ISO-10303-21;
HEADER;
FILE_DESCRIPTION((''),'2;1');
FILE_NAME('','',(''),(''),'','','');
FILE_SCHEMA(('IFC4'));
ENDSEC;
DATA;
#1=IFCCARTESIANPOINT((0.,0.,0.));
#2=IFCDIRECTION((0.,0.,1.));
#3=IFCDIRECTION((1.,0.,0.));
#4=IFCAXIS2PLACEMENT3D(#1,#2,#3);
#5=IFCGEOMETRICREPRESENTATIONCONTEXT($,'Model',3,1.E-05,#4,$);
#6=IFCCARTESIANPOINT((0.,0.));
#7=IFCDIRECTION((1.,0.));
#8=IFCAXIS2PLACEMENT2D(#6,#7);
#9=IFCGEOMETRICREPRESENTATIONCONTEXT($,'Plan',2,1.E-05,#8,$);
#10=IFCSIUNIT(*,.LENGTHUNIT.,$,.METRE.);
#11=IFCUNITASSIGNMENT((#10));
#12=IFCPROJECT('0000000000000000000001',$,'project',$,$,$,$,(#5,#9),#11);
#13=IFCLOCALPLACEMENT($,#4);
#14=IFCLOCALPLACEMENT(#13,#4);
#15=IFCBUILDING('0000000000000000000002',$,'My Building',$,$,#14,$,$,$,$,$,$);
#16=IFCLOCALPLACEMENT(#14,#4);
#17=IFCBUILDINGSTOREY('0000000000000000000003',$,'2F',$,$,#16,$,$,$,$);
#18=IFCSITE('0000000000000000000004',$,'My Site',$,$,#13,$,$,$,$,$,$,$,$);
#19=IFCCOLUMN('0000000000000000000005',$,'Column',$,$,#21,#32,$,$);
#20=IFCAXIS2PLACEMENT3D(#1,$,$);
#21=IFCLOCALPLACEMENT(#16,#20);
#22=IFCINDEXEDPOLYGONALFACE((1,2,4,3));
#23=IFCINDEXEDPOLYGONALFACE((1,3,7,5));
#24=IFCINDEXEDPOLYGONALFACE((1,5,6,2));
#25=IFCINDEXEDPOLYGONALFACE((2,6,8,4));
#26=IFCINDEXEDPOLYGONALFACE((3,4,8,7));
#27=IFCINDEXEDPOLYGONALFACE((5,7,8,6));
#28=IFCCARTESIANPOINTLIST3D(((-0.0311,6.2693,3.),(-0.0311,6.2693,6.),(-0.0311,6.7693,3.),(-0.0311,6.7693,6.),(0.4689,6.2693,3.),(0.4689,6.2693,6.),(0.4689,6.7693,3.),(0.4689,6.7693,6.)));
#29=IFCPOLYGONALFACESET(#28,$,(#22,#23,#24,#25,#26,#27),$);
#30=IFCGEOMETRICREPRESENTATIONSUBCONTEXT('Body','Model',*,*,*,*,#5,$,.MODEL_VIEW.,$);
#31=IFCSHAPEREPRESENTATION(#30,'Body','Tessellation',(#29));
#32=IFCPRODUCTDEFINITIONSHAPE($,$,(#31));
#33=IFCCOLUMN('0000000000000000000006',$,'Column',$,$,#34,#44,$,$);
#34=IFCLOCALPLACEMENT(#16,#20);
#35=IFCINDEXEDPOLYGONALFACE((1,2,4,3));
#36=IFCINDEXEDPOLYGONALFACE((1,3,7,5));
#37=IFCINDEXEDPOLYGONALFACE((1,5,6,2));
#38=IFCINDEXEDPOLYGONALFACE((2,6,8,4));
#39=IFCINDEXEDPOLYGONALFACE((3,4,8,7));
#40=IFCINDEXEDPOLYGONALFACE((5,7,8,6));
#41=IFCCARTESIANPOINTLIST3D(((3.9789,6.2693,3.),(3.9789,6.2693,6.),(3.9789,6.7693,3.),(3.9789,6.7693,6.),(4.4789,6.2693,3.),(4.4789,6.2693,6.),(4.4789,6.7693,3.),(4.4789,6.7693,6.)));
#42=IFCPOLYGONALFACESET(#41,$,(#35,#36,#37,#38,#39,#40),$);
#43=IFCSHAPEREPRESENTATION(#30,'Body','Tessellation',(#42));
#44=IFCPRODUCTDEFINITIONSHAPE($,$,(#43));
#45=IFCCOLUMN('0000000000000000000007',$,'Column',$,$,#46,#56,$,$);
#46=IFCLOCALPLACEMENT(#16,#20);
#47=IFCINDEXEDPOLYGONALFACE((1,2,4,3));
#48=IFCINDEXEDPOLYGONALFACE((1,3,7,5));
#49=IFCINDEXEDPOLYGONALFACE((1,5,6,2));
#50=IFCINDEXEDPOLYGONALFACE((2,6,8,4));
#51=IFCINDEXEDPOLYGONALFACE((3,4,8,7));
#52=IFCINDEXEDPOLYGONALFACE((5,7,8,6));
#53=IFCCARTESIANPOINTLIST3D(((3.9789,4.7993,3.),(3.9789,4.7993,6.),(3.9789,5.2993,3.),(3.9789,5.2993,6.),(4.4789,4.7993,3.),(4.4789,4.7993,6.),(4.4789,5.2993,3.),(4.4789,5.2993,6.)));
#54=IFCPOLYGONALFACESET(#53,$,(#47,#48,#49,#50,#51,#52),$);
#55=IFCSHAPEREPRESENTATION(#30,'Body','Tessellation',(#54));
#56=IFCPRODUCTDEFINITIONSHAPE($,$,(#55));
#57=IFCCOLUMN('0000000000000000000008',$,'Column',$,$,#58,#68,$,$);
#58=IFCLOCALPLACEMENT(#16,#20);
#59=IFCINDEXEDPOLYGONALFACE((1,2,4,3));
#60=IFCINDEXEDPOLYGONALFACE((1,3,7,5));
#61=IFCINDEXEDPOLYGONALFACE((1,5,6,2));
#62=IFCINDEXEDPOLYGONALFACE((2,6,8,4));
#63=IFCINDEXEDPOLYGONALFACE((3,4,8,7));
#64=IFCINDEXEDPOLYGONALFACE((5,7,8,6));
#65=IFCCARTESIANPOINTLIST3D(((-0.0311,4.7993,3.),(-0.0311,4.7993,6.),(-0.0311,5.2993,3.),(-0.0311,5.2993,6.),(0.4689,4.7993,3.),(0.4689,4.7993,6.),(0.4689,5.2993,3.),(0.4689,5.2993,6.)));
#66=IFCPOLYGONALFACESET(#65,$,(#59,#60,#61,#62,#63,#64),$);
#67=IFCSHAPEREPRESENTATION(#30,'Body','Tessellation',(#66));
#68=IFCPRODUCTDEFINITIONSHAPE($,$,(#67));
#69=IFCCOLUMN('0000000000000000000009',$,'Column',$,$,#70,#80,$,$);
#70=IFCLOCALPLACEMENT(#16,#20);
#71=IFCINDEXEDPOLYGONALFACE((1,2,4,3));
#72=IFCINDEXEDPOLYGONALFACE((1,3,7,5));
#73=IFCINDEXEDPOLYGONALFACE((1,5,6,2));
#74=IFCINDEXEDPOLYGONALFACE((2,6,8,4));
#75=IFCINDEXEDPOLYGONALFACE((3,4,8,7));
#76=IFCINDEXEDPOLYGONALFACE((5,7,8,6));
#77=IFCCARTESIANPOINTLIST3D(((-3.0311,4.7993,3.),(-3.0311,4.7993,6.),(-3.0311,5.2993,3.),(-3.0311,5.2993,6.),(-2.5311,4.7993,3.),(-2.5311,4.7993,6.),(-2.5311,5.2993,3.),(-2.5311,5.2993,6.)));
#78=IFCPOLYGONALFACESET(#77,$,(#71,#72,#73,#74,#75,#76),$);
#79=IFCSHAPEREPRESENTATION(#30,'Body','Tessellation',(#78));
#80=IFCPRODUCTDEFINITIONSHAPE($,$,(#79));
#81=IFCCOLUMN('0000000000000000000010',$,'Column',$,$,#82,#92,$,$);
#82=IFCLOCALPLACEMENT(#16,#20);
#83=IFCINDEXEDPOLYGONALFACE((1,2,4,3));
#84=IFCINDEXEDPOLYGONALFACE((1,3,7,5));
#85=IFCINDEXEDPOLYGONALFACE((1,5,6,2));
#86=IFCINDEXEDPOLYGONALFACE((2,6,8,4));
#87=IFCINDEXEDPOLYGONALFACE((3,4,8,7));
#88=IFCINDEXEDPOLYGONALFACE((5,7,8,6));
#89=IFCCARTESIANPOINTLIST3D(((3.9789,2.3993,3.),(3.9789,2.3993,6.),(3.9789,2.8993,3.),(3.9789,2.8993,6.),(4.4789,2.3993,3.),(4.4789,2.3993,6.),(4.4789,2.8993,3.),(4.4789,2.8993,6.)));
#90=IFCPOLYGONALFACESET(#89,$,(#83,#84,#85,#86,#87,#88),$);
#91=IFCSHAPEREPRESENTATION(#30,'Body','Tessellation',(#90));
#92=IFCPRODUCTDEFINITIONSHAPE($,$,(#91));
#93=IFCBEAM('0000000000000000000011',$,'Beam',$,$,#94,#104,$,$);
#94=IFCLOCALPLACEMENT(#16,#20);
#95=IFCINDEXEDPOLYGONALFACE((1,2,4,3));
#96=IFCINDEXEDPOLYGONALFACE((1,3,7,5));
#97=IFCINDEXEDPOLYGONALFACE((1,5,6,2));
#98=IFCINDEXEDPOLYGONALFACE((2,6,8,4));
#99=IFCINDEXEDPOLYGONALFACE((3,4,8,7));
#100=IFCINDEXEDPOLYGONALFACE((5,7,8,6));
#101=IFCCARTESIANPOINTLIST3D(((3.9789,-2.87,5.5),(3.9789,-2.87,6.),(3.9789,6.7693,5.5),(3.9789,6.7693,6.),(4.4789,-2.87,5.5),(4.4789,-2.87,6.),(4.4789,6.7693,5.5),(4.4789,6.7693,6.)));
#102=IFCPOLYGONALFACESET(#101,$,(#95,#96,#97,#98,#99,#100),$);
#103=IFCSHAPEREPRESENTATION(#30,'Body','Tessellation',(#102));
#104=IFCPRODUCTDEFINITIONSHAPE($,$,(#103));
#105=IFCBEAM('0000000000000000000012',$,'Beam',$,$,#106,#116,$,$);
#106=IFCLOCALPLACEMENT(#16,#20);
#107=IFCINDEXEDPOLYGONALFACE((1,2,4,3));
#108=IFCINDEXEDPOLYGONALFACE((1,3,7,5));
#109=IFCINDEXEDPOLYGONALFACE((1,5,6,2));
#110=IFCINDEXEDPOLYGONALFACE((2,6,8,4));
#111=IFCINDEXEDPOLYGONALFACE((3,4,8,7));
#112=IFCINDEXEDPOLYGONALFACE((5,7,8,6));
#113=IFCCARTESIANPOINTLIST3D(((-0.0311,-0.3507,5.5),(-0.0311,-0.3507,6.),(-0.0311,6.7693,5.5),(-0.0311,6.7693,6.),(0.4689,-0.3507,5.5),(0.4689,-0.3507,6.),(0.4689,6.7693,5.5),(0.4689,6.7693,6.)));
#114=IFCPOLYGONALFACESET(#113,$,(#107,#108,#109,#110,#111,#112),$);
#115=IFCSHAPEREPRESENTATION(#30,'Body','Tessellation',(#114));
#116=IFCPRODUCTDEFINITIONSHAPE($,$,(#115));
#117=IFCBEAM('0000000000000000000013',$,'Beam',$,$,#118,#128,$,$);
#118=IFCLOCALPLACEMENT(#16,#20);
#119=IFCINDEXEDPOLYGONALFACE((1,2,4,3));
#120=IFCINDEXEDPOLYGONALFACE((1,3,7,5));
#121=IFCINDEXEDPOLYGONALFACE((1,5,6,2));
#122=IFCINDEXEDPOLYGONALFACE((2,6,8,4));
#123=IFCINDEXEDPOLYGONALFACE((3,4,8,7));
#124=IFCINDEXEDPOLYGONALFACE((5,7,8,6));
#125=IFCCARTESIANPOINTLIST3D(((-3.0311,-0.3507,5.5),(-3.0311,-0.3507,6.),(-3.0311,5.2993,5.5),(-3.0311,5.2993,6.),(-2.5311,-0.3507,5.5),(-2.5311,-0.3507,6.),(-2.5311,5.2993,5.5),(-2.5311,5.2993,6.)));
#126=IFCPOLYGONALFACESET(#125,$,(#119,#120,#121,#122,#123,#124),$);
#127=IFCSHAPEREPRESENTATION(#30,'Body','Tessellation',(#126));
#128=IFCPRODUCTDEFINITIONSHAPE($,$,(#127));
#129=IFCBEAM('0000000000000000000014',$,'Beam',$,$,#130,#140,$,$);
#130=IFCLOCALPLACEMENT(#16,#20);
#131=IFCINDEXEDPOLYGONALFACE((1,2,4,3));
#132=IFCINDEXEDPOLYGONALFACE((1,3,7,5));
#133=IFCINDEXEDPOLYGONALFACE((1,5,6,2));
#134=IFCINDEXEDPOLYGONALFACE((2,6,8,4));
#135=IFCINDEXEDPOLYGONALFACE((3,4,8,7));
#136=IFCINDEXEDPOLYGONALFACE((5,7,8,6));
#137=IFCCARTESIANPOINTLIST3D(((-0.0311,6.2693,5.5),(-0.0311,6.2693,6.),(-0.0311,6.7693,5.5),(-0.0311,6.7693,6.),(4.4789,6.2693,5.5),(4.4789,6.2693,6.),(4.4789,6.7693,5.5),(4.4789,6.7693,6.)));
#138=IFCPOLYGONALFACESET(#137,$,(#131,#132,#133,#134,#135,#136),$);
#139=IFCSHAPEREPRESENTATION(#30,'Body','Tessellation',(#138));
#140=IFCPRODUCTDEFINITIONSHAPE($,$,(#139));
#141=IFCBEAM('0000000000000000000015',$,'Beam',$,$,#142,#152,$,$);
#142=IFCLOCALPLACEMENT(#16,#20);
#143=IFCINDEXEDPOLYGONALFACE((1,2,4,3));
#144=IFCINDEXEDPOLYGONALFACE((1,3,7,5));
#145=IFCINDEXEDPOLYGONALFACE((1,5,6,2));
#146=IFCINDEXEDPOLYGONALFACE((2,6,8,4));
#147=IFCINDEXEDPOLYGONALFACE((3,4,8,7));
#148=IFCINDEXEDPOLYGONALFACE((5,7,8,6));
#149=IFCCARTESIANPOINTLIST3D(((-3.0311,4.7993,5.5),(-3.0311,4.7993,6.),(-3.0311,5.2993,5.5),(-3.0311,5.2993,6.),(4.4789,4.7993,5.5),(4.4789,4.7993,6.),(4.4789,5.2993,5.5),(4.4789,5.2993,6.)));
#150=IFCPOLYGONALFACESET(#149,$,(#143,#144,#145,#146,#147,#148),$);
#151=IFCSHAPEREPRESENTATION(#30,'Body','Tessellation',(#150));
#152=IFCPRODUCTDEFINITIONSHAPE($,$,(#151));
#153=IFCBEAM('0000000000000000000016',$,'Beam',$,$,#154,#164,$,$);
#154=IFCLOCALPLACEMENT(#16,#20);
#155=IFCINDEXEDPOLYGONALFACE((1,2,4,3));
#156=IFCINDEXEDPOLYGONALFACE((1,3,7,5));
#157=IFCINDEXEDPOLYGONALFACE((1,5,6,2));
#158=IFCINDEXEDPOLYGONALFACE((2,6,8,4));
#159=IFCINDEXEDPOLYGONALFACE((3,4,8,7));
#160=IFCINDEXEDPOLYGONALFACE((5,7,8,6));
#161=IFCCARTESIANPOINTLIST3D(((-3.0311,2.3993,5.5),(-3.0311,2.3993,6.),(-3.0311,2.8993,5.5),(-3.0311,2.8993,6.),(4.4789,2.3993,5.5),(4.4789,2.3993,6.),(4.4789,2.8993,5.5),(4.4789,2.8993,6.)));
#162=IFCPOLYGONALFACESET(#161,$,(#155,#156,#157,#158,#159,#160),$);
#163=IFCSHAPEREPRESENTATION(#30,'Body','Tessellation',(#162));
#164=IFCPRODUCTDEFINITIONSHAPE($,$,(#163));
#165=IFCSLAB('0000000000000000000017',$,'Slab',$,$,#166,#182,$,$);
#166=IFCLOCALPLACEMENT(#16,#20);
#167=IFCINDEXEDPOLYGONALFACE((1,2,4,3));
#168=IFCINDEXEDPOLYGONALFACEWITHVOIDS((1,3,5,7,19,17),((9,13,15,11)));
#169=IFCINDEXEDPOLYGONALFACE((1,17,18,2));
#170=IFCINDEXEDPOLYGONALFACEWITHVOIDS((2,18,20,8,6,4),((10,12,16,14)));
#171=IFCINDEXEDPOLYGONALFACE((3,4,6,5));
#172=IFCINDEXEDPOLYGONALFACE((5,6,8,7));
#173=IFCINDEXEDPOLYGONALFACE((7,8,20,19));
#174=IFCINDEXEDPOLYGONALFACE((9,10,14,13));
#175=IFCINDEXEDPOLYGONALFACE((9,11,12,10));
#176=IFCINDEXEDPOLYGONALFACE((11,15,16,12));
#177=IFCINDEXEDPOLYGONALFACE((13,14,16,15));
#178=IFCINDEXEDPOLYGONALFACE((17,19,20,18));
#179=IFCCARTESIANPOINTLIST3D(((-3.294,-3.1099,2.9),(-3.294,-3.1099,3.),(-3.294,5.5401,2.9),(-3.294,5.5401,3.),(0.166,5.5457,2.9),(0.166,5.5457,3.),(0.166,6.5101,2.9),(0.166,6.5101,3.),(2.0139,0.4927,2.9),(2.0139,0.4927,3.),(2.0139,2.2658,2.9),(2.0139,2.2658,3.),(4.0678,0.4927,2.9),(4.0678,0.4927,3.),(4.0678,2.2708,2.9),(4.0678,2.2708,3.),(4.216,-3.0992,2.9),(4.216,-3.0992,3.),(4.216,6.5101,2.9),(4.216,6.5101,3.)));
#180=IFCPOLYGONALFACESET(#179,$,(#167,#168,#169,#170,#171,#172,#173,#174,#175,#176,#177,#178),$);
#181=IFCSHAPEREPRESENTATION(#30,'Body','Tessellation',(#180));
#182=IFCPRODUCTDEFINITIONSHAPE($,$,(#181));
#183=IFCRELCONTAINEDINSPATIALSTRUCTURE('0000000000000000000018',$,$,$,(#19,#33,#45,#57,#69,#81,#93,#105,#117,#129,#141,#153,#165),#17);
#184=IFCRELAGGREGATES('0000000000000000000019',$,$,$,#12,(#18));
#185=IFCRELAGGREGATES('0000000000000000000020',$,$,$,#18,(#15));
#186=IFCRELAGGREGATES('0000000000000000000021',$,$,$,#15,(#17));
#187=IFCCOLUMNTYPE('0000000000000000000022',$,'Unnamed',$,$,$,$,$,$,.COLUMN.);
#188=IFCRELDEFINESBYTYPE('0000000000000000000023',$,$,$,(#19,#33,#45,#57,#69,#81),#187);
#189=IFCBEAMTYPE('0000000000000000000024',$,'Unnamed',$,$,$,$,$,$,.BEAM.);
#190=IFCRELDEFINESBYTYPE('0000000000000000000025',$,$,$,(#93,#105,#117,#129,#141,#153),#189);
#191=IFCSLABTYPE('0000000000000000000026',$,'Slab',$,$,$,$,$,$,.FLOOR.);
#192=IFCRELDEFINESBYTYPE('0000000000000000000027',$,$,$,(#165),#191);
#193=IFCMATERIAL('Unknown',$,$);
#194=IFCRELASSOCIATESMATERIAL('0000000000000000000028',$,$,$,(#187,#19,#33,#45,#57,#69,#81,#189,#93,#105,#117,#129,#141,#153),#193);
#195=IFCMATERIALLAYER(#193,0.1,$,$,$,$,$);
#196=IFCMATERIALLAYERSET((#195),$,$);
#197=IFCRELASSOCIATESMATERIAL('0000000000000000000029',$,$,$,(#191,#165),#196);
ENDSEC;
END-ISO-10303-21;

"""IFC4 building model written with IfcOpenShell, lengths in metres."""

from ifc_helpers import new_model, si_unit, frame, origin_with_axes, origin_2d_with_axis, place, context, subcontext, project, spatial, indexed_curve, rectangle, outline, extrude, material, layer, layer_set, layer_usage, material_profile, profile_set, profile_usage, type_object, element, save


model = new_model("IFC4")

# Units and contexts
model_context = context("Model", 3, precision=1e-05, world=origin_with_axes())
plan_context = context("Plan", 2, precision=1e-05, world=origin_2d_with_axis())
body_context_1 = subcontext(model_context, "Body", "Model", "MODEL_VIEW")
ifc_project = project(units=[si_unit("LENGTHUNIT", "METRE")], contexts=[model_context, plan_context])

# Site, building, storey
site_placement = place(None, origin_with_axes())
site = spatial("IfcSite", under=ifc_project, at=site_placement, Name="My Site")
building_placement = place(site_placement, origin_with_axes())
building = spatial("IfcBuilding", under=site, at=building_placement, Name="My Building")
storey_placement = place(building_placement, origin_with_axes())
storey = spatial("IfcBuildingStorey", under=building, at=storey_placement, Name="2F")

# Columns
ifc_material = material(Name="Unknown")
ifc_material_profile_1 = material_profile(ifc_material, rectangle(XDim=0.5, YDim=0.5))
ifc_profile_set_1 = profile_set([ifc_material_profile_1])
ifc_profile_usage_1 = profile_usage(ifc_profile_set_1, cardinal=7)
column_type = type_object("IfcColumnType", Name="Unnamed", PredefinedType="COLUMN", material=ifc_profile_set_1)
column_1_placement = place(storey_placement, frame((0.4689, 6.7693, 3.0), z_axis=(0.0, 0.0, 1.0), x_axis=(1.0, 0.0, 0.0)))
element("IfcColumn", 1, at=column_1_placement, inside=storey, type_object=column_type, material=ifc_profile_usage_1, Name="Column", context=body_context_1, shape_type="SweptSolid", body=[
    extrude(rectangle(XDim=0.5, YDim=0.5), frame((-0.25, -0.25, 0.0), z_axis=(0.0, 0.0, 1.0), x_axis=(1.0, 0.0, 0.0)), (0.0, 0.0, 1.0), 3.0),
])
ifc_profile_usage_2 = profile_usage(ifc_profile_set_1, cardinal=7)
column_2_placement = place(storey_placement, frame((4.4789, 6.7693, 3.0), z_axis=(0.0, 0.0, 1.0), x_axis=(1.0, 0.0, 0.0)))
element("IfcColumn", 2, at=column_2_placement, inside=storey, type_object=column_type, material=ifc_profile_usage_2, Name="Column", context=body_context_1, shape_type="SweptSolid", body=[
    extrude(rectangle(XDim=0.5, YDim=0.5), frame((-0.25, -0.25, 0.0), z_axis=(0.0, 0.0, 1.0), x_axis=(1.0, 0.0, 0.0)), (0.0, 0.0, 1.0), 3.0),
])
ifc_profile_usage_3 = profile_usage(ifc_profile_set_1, cardinal=7)
column_3_placement = place(storey_placement, frame((4.4789, 5.2993, 3.0), z_axis=(0.0, 0.0, 1.0), x_axis=(1.0, 0.0, 0.0)))
element("IfcColumn", 3, at=column_3_placement, inside=storey, type_object=column_type, material=ifc_profile_usage_3, Name="Column", context=body_context_1, shape_type="SweptSolid", body=[
    extrude(rectangle(XDim=0.5, YDim=0.5), frame((-0.25, -0.25, 0.0), z_axis=(0.0, 0.0, 1.0), x_axis=(1.0, 0.0, 0.0)), (0.0, 0.0, 1.0), 3.0),
])
ifc_profile_usage_4 = profile_usage(ifc_profile_set_1, cardinal=7)
column_4_placement = place(storey_placement, frame((0.4689, 5.2993, 3.0), z_axis=(0.0, 0.0, 1.0), x_axis=(1.0, 0.0, 0.0)))
element("IfcColumn", 4, at=column_4_placement, inside=storey, type_object=column_type, material=ifc_profile_usage_4, Name="Column", context=body_context_1, shape_type="SweptSolid", body=[
    extrude(rectangle(XDim=0.5, YDim=0.5), frame((-0.25, -0.25, 0.0), z_axis=(0.0, 0.0, 1.0), x_axis=(1.0, 0.0, 0.0)), (0.0, 0.0, 1.0), 3.0),
])
ifc_profile_usage_5 = profile_usage(ifc_profile_set_1, cardinal=7)
column_5_placement = place(storey_placement, frame((-2.5311, 5.2993, 3.0), z_axis=(0.0, 0.0, 1.0), x_axis=(1.0, 0.0, 0.0)))
element("IfcColumn", 5, at=column_5_placement, inside=storey, type_object=column_type, material=ifc_profile_usage_5, Name="Column", context=body_context_1, shape_type="SweptSolid", body=[
    extrude(rectangle(XDim=0.5, YDim=0.5), frame((-0.25, -0.25, 0.0), z_axis=(0.0, 0.0, 1.0), x_axis=(1.0, 0.0, 0.0)), (0.0, 0.0, 1.0), 3.0),
])
ifc_profile_usage_6 = profile_usage(ifc_profile_set_1, cardinal=7)
column_6_placement = place(storey_placement, frame((4.4789, 2.8993, 3.0), z_axis=(0.0, 0.0, 1.0), x_axis=(1.0, 0.0, 0.0)))
element("IfcColumn", 6, at=column_6_placement, inside=storey, type_object=column_type, material=ifc_profile_usage_6, Name="Column", context=body_context_1, shape_type="SweptSolid", body=[
    extrude(rectangle(XDim=0.5, YDim=0.5), frame((-0.25, -0.25, 0.0), z_axis=(0.0, 0.0, 1.0), x_axis=(1.0, 0.0, 0.0)), (0.0, 0.0, 1.0), 3.0),
])

# Beams
ifc_material_profile_2 = material_profile(ifc_material, rectangle(XDim=0.5, YDim=0.5))
ifc_profile_set_2 = profile_set([ifc_material_profile_2])
ifc_profile_usage_7 = profile_usage(ifc_profile_set_2, cardinal=7)
beam_type = type_object("IfcBeamType", Name="Unnamed", PredefinedType="BEAM", material=ifc_profile_set_2)
beam_1_placement = place(storey_placement, frame((4.4789, 6.7693, 6.0), z_axis=(0.0, -1.0, 0.0), x_axis=(1.0, 0.0, 0.0)))
element("IfcBeam", 7, at=beam_1_placement, inside=storey, type_object=beam_type, material=ifc_profile_usage_7, Name="Beam", context=body_context_1, shape_type="SweptSolid", body=[
    extrude(rectangle(XDim=0.5, YDim=0.5), frame((-0.25, -0.25, 0.0), z_axis=(0.0, 0.0, 1.0), x_axis=(1.0, 0.0, 0.0)), (0.0, 0.0, 1.0), 9.6393),
])
ifc_profile_usage_8 = profile_usage(ifc_profile_set_2, cardinal=7)
beam_2_placement = place(storey_placement, frame((0.4689, 6.7693, 6.0), z_axis=(0.0, -1.0, 0.0), x_axis=(1.0, 0.0, 0.0)))
element("IfcBeam", 8, at=beam_2_placement, inside=storey, type_object=beam_type, material=ifc_profile_usage_8, Name="Beam", context=body_context_1, shape_type="SweptSolid", body=[
    extrude(rectangle(XDim=0.5, YDim=0.5), frame((-0.25, -0.25, 0.0), z_axis=(0.0, 0.0, 1.0), x_axis=(1.0, 0.0, 0.0)), (0.0, 0.0, 1.0), 7.12),
])
ifc_profile_usage_9 = profile_usage(ifc_profile_set_2, cardinal=7)
beam_3_placement = place(storey_placement, frame((-2.5311, 5.2993, 6.0), z_axis=(0.0, -1.0, 0.0), x_axis=(1.0, 0.0, 0.0)))
element("IfcBeam", 9, at=beam_3_placement, inside=storey, type_object=beam_type, material=ifc_profile_usage_9, Name="Beam", context=body_context_1, shape_type="SweptSolid", body=[
    extrude(rectangle(XDim=0.5, YDim=0.5), frame((-0.25, -0.25, 0.0), z_axis=(0.0, 0.0, 1.0), x_axis=(1.0, 0.0, 0.0)), (0.0, 0.0, 1.0), 5.65),
])
ifc_profile_usage_10 = profile_usage(ifc_profile_set_2, cardinal=7)
beam_4_placement = place(storey_placement, frame((-0.0311, 6.7693, 6.0), z_axis=(1.0, -0.000001, 0.000001), x_axis=(0.000001, 1.0, 0.0)))
element("IfcBeam", 10, at=beam_4_placement, inside=storey, type_object=beam_type, material=ifc_profile_usage_10, Name="Beam", context=body_context_1, shape_type="SweptSolid", body=[
    extrude(rectangle(XDim=0.5, YDim=0.5), frame((-0.25, -0.25, 0.0), z_axis=(0.0, 0.0, 1.0), x_axis=(1.0, 0.0, 0.0)), (0.0, 0.0, 1.0), 4.51),
])
ifc_profile_usage_11 = profile_usage(ifc_profile_set_2, cardinal=7)
beam_5_placement = place(storey_placement, frame((-3.0311, 5.2993, 6.0), z_axis=(1.0, -0.000001, 0.000001), x_axis=(0.000001, 1.0, 0.0)))
element("IfcBeam", 11, at=beam_5_placement, inside=storey, type_object=beam_type, material=ifc_profile_usage_11, Name="Beam", context=body_context_1, shape_type="SweptSolid", body=[
    extrude(rectangle(XDim=0.5, YDim=0.5), frame((-0.25, -0.25, 0.0), z_axis=(0.0, 0.0, 1.0), x_axis=(1.0, 0.0, 0.0)), (0.0, 0.0, 1.0), 7.51),
])
ifc_profile_usage_12 = profile_usage(ifc_profile_set_2, cardinal=7)
beam_6_placement = place(storey_placement, frame((-3.0311, 2.8993, 6.0), z_axis=(1.0, -0.000001, 0.000001), x_axis=(0.000001, 1.0, 0.0)))
element("IfcBeam", 12, at=beam_6_placement, inside=storey, type_object=beam_type, material=ifc_profile_usage_12, Name="Beam", context=body_context_1, shape_type="SweptSolid", body=[
    extrude(rectangle(XDim=0.5, YDim=0.5), frame((-0.25, -0.25, 0.0), z_axis=(0.0, 0.0, 1.0), x_axis=(1.0, 0.0, 0.0)), (0.0, 0.0, 1.0), 7.51),
])

# Slab
ifc_layer_1 = layer(ifc_material, 0.1)
ifc_layer_set_1 = layer_set([ifc_layer_1])
ifc_layer_usage_1 = layer_usage(ifc_layer_set_1, "AXIS3", "POSITIVE", -0.1)
slab_type = type_object("IfcSlabType", Name="Slab", PredefinedType="FLOOR", material=ifc_layer_set_1)
slab_placement = place(storey_placement, frame((-3.294, 5.5401, 3.0), z_axis=(0.0, 0.0, 1.0), x_axis=(1.0, 0.0, 0.0)))
element("IfcSlab", 13, at=slab_placement, inside=storey, type_object=slab_type, material=ifc_layer_usage_1, Name="Slab", context=body_context_1, shape_type="SweptSolid", body=[
    extrude(outline(indexed_curve([(0.0, 0.0), (0.0, -8.65), (7.51, -8.6394), (7.51, 0.97), (3.46, 0.97), (3.46, 0.0056), (0.0, 0.0)]), holes=[indexed_curve([(5.3079, -5.0474), (7.3618, -5.0474), (7.3618, -3.2693), (5.3079, -3.2743), (5.3079, -5.0474)])]), frame((0.0, 0.0, -0.1), z_axis=(0.0, 0.0, 1.0), x_axis=(1.0, 0.0, 0.0)), (0.0, 0.0, 1.0), 0.1),
])

save(model, "model.ifc")
